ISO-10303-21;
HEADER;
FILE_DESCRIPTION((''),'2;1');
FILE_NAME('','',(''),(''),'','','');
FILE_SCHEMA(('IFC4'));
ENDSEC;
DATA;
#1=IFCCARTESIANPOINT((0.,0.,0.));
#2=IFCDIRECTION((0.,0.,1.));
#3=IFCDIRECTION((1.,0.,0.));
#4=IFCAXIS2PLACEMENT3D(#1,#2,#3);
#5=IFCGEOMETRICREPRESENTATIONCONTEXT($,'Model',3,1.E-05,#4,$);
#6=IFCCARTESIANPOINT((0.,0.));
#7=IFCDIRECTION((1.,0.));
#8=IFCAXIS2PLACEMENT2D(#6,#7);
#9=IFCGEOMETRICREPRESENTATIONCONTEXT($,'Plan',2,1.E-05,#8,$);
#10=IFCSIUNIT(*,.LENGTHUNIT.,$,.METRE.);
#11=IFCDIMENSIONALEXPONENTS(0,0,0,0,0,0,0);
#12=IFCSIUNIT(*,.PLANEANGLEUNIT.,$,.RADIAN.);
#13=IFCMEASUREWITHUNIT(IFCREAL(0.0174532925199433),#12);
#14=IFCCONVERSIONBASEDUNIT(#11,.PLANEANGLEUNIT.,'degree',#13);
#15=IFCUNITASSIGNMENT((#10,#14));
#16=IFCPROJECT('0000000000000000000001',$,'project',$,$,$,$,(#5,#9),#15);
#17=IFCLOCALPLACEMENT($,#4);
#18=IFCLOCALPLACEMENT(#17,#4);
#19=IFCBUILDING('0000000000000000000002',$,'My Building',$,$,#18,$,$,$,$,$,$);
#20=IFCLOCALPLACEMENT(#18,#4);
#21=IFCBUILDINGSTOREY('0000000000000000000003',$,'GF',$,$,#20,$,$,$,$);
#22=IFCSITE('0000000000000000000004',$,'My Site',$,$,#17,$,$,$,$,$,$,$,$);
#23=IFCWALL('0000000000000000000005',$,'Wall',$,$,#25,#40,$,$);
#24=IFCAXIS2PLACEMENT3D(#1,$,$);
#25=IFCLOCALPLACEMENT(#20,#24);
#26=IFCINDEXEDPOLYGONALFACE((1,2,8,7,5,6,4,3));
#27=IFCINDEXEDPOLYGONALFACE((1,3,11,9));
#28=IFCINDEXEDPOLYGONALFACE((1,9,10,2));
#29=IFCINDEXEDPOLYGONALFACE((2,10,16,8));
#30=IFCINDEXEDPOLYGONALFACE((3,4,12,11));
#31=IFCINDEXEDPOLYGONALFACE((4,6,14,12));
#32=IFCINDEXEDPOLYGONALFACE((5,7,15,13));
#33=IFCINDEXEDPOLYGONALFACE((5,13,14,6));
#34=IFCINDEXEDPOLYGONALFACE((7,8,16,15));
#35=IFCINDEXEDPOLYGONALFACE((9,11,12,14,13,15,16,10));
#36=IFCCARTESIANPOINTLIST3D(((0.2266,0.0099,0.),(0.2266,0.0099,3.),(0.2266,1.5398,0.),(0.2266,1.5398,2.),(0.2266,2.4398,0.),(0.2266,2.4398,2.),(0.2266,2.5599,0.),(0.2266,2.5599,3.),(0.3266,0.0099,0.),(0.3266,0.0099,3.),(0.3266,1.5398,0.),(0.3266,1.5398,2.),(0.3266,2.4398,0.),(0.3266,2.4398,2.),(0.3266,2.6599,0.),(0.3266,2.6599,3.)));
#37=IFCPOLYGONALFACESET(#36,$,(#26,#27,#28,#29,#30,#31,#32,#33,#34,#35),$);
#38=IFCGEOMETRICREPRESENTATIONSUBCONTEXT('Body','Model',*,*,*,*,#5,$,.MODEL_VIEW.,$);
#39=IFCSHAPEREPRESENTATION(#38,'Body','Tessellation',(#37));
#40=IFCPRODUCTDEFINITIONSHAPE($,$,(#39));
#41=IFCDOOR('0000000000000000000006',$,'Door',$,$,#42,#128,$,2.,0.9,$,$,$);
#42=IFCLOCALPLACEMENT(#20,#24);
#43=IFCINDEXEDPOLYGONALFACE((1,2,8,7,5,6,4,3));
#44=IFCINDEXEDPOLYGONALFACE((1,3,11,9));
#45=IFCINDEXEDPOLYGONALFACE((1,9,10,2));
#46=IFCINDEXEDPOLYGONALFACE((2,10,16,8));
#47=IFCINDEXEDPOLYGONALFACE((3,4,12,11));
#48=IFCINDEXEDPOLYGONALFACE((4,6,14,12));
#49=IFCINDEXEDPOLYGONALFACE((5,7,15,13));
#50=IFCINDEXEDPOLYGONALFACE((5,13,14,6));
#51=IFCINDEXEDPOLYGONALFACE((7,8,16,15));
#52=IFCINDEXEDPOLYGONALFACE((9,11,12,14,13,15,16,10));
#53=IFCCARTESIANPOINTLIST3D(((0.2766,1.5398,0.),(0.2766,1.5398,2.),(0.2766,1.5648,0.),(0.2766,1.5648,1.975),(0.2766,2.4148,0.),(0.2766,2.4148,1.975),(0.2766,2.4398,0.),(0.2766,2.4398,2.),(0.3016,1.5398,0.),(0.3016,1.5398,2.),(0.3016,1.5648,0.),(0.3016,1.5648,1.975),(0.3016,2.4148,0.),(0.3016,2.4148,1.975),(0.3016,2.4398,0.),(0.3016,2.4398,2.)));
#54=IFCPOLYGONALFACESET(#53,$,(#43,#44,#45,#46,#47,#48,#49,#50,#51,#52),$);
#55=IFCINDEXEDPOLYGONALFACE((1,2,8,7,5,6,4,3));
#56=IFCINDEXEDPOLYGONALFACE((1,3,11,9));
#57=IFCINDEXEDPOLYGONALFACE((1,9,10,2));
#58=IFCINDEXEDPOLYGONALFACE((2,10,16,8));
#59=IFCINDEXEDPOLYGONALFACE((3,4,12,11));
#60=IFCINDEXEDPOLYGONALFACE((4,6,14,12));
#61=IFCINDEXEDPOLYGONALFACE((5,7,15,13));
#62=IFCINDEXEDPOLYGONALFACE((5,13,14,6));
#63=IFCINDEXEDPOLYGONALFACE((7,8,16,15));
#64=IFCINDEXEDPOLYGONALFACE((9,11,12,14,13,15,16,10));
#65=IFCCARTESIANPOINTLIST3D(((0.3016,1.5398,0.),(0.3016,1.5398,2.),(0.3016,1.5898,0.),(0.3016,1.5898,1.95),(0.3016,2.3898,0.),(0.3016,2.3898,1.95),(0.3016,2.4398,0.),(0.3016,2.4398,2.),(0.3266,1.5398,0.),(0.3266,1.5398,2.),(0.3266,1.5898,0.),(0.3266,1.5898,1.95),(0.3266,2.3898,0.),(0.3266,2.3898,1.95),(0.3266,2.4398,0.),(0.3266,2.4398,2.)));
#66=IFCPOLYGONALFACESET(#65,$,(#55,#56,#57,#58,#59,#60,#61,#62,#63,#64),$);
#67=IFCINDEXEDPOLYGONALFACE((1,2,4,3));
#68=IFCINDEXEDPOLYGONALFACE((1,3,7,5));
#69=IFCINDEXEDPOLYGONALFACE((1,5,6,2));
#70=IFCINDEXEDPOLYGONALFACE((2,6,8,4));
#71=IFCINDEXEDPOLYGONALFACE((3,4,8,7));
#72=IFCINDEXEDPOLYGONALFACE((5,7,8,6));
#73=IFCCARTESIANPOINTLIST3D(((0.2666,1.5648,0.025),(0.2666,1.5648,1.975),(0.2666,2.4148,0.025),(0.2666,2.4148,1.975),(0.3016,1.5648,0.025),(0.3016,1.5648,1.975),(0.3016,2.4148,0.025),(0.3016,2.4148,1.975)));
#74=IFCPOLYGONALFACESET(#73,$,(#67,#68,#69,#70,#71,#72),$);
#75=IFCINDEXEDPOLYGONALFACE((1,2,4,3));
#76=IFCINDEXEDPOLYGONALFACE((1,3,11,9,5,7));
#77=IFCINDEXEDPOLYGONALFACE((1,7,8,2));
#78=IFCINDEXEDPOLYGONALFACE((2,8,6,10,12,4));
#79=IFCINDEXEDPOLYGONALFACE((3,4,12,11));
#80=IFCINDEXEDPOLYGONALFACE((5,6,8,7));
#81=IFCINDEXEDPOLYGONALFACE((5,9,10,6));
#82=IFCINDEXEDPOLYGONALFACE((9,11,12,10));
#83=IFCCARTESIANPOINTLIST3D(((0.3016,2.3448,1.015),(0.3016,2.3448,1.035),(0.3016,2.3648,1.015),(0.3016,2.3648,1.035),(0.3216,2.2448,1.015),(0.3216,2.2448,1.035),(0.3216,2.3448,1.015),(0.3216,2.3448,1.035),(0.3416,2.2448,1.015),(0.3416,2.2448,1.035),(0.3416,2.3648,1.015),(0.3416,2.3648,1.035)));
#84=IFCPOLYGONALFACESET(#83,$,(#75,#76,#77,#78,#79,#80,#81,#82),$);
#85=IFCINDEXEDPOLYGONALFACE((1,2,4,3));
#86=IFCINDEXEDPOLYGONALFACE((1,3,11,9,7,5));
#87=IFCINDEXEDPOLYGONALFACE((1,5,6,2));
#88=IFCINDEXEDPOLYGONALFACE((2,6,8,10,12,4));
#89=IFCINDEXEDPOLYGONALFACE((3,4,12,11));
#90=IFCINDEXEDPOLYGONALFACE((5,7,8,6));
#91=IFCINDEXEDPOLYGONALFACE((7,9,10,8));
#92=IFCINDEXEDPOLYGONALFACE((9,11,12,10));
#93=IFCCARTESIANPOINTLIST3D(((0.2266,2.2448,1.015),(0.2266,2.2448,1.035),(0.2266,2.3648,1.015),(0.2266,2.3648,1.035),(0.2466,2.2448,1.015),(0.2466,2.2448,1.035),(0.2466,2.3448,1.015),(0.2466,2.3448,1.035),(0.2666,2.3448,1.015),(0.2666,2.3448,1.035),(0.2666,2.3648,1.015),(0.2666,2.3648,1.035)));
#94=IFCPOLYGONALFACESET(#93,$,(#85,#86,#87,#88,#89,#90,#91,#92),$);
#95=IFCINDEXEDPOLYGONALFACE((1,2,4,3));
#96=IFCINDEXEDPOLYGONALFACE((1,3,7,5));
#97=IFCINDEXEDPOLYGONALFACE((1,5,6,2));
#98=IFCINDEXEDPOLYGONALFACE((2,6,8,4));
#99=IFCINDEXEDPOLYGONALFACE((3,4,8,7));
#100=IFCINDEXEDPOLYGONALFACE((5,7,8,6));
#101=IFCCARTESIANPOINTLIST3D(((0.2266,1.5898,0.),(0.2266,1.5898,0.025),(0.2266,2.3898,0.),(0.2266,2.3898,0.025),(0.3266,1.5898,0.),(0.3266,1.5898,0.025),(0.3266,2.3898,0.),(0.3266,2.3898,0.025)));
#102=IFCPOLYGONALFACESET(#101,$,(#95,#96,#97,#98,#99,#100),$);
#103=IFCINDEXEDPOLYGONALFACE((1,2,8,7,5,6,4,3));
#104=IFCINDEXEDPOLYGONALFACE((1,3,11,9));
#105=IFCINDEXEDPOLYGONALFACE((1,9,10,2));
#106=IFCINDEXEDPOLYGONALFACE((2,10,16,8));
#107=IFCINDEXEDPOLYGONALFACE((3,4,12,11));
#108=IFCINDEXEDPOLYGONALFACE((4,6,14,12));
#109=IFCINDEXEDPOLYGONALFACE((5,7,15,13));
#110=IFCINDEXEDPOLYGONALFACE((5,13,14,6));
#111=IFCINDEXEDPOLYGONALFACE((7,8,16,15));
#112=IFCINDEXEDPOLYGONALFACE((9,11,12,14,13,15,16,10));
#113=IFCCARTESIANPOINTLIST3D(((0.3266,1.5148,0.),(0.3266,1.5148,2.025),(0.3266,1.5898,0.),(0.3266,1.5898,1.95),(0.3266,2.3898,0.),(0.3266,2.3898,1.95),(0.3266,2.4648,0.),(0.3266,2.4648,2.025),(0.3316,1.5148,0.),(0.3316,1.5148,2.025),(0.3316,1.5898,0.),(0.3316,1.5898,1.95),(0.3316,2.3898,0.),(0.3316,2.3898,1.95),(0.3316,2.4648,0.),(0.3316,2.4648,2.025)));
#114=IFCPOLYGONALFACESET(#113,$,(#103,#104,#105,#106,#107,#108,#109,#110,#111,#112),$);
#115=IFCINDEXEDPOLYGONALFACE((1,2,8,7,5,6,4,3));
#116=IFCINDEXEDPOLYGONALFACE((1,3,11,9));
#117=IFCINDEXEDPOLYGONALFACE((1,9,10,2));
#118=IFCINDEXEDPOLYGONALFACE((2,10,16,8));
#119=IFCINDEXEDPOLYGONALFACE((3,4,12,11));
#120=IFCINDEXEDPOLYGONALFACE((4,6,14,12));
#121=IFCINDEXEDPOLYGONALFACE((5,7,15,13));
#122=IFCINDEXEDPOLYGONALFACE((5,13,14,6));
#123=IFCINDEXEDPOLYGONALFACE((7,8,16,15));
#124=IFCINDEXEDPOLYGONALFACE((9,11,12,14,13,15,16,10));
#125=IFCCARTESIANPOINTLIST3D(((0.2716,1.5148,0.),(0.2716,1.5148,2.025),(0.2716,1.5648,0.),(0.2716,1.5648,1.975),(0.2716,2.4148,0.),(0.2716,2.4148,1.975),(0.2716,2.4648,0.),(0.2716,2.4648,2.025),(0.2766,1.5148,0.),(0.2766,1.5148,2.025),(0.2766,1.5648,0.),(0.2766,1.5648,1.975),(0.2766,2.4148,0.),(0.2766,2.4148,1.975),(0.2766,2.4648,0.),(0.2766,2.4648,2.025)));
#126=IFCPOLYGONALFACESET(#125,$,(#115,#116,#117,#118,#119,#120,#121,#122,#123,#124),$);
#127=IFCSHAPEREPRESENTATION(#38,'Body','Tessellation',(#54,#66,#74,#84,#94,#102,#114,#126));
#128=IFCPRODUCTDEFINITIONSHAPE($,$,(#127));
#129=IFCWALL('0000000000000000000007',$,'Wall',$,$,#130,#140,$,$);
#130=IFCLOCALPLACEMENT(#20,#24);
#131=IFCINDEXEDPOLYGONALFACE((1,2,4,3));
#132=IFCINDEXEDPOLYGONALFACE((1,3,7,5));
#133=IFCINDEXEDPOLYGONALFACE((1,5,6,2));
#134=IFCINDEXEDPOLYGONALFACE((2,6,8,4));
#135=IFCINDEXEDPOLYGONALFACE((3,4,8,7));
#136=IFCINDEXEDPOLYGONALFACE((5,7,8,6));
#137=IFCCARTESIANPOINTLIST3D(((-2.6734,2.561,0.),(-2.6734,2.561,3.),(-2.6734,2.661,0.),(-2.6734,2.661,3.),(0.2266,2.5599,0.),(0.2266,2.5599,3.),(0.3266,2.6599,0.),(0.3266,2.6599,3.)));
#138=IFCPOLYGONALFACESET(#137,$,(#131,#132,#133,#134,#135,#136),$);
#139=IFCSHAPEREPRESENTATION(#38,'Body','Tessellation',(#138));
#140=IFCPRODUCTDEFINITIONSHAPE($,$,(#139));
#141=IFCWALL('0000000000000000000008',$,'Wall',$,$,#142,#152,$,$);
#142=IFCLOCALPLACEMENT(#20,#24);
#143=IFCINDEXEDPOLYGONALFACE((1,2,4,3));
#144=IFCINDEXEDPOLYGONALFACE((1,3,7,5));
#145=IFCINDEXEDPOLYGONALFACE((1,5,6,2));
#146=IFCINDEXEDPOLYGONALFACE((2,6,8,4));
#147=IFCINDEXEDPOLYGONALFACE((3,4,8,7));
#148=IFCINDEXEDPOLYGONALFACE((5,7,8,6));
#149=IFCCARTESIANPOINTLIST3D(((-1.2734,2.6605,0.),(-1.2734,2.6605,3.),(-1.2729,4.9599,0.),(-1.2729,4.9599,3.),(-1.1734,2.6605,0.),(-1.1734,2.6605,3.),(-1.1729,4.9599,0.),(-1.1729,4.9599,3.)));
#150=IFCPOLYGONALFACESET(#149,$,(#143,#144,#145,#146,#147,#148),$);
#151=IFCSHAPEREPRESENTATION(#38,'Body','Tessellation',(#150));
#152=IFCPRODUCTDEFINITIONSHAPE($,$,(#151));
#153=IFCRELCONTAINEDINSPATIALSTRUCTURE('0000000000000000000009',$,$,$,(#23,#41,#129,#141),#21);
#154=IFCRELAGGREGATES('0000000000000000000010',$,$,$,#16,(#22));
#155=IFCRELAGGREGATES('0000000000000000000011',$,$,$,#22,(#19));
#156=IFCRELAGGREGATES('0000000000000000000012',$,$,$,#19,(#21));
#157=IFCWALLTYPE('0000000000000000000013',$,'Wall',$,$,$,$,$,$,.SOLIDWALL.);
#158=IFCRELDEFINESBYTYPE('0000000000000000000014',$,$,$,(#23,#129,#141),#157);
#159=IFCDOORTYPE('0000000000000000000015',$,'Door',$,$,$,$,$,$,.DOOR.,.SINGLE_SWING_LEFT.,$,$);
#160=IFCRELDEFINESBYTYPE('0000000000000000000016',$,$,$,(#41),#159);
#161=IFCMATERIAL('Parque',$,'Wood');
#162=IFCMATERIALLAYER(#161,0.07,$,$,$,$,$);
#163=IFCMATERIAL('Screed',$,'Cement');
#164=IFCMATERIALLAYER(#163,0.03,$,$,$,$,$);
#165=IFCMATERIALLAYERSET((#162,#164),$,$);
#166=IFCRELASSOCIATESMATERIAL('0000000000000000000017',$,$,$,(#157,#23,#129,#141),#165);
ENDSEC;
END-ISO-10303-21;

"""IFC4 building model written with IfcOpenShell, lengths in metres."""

from ifc_helpers import new_model, entity, si_unit, converted_unit, frame, origin_with_axes, origin_2d_with_axis, place, context, subcontext, project, spatial, line, indexed_curve, outline, extrude, shape, source, transform, mapped, material, layer, layer_set, layer_usage, type_object, type_shapes, element, fill, save


model = new_model("IFC4")

# Units and contexts
model_context = context("Model", 3, precision=1e-05, world=origin_with_axes())
plan_context = context("Plan", 2, precision=1e-05, world=origin_2d_with_axis())
body_context_1 = subcontext(model_context, "Body", "Model", "MODEL_VIEW")
body_context_2 = subcontext(plan_context, "Body", "Plan", "PLAN_VIEW")
ifc_project = project(units=[si_unit("LENGTHUNIT", "METRE"), converted_unit("PLANEANGLEUNIT", "degree", entity("IfcReal", 0.0174532925199433), si_unit("PLANEANGLEUNIT", "RADIAN"), dimensions=[0, 0, 0, 0, 0, 0, 0])], contexts=[model_context, plan_context])

# Site, building, storey
site_placement = place(None, origin_with_axes())
site = spatial("IfcSite", under=ifc_project, at=site_placement, Name="My Site")
building_placement = place(site_placement, origin_with_axes())
building = spatial("IfcBuilding", under=site, at=building_placement, Name="My Building")
storey_placement = place(building_placement, origin_with_axes())
storey = spatial("IfcBuildingStorey", under=building, at=storey_placement, Name="GF")

# Shared definitions
ifc_material_1 = material(Name="Parque", Category="Wood")
ifc_layer_1 = layer(ifc_material_1, 0.07)
ifc_material_2 = material(Name="Screed", Category="Cement")
ifc_layer_2 = layer(ifc_material_2, 0.03)
ifc_layer_set_1 = layer_set([ifc_layer_1, ifc_layer_2])
wall_type = type_object("IfcWallType", Name="Wall", PredefinedType="SOLIDWALL", material=ifc_layer_set_1)
shared_shape_1 = source(origin_with_axes(), body_context_1, "Body", "SweptSolid", [
    extrude(outline(indexed_curve([(0.0, 0.0), (0.9, 0.0), (0.9, 2.0), (0.0, 2.0)], segments=[line(1, 2, 3, 4, 1)])), frame((0.0, -0.6, 0.0), z_axis=(0.0, -1.0, 0.0), x_axis=(1.0, 0.0, 0.0)), (0.0, 0.0, -1.0), 1.2),
])
door_type = type_object("IfcDoorType", Name="Door", OperationType="SINGLE_SWING_LEFT", PredefinedType="DOOR")
shared_shape_2 = source(origin_with_axes(), body_context_1, "Body", "SweptSolid", [
    extrude(outline(indexed_curve([(0.0, 0.0), (0.0, 2.0), (0.9, 2.0), (0.9, 0.0), (0.875, 0.0), (0.875, 1.975), (0.025, 1.975), (0.025, 0.0)], segments=[line(1, 2, 3, 4, 5, 6, 7, 8, 1)])), frame((0.0, 0.025, 0.0), z_axis=(0.0, -1.0, 0.0), x_axis=(1.0, 0.0, 0.0)), (0.0, 0.0, -1.0), 0.025),
    extrude(outline(indexed_curve([(0.0, 0.0), (0.0, 2.0), (0.9, 2.0), (0.9, 0.0), (0.85, 0.0), (0.85, 1.95), (0.05, 1.95), (0.05, 0.0)], segments=[line(1, 2, 3, 4, 5, 6, 7, 8, 1)])), frame((0.0, 0.0, 0.0), z_axis=(0.0, -1.0, 0.0), x_axis=(1.0, 0.0, 0.0)), (0.0, 0.0, -1.0), 0.025),
    extrude(outline(indexed_curve([(0.0, 0.0), (0.85, 0.0), (0.85, 0.035), (0.0, 0.035)], segments=[line(1, 2, 3, 4, 1)])), frame((0.025, 0.025, 0.025), z_axis=(0.0, 0.0, 1.0), x_axis=(1.0, 0.0, 0.0)), (0.0, 0.0, 1.0), 1.95),
    extrude(outline(indexed_curve([(0.0, 0.0), (0.0, -0.04), (-0.12, -0.04), (-0.12, -0.02), (-0.02, -0.02), (-0.02, 0.0)], segments=[line(1, 2, 3, 4, 5, 6, 1)])), frame((0.825, 0.025, 1.015), z_axis=(0.0, 0.0, 1.0), x_axis=(1.0, 0.0, 0.0)), (0.0, 0.0, 1.0), 0.02),
    extrude(outline(indexed_curve([(0.0, 0.0), (0.0, 0.04), (-0.12, 0.04), (-0.12, 0.02), (-0.02, 0.02), (-0.02, 0.0)], segments=[line(1, 2, 3, 4, 5, 6, 1)])), frame((0.825, 0.06, 1.015), z_axis=(0.0, 0.0, 1.0), x_axis=(1.0, 0.0, 0.0)), (0.0, 0.0, 1.0), 0.02),
    extrude(outline(indexed_curve([(0.0, 0.0), (0.8, 0.0), (0.8, 0.1), (0.0, 0.1)], segments=[line(1, 2, 3, 4, 1)])), frame((0.05, 0.0, 0.0), z_axis=(0.0, 0.0, 1.0), x_axis=(1.0, 0.0, 0.0)), (0.0, 0.0, 1.0), 0.025),
    extrude(outline(indexed_curve([(0.0, 0.0), (0.0, 2.025), (0.95, 2.025), (0.95, 0.0), (0.875, 0.0), (0.875, 1.95), (0.075, 1.95), (0.075, 0.0)], segments=[line(1, 2, 3, 4, 5, 6, 7, 8, 1)])), frame((-0.025, -0.005, 0.0), z_axis=(0.0, -1.0, 0.0), x_axis=(1.0, 0.0, 0.0)), (0.0, 0.0, -1.0), 0.005),
    extrude(outline(indexed_curve([(0.0, 0.0), (0.0, 2.025), (0.95, 2.025), (0.95, 0.0), (0.9, 0.0), (0.9, 1.975), (0.05, 1.975), (0.05, 0.0)], segments=[line(1, 2, 3, 4, 5, 6, 7, 8, 1)])), frame((-0.025, 0.05, 0.0), z_axis=(0.0, -1.0, 0.0), x_axis=(1.0, 0.0, 0.0)), (0.0, 0.0, -1.0), 0.005),
])
shared_shape_3 = source(origin_with_axes(), body_context_2, "Body", "Curve2D", [
    entity("IfcIndexedPolyCurve", entity("IfcCartesianPointList2D", [[0.0, 0.0], [0.0, 0.05], [0.025, 0.05], [0.025, 0.025], [0.05, 0.025], [0.05, 0.0]]), [entity("IfcLineIndex", [1, 2, 3, 4, 5, 6, 1])]),
    entity("IfcIndexedPolyCurve", entity("IfcCartesianPointList2D", [[0.9, 0.0], [0.9, 0.05], [0.875, 0.05], [0.875, 0.025], [0.85, 0.025], [0.85, 0.0]]), [entity("IfcLineIndex", [1, 2, 3, 4, 5, 6, 1])]),
    entity("IfcTrimmedCurve", entity("IfcEllipse", entity("IfcAxis2Placement2D", entity("IfcCartesianPoint", [0.06, 0.05]), entity("IfcDirection", [1.0, 0.0])), 0.815, 0.85), [entity("IfcCartesianPoint", [0.875, 0.05])], [entity("IfcCartesianPoint", [0.06, 0.9])], True, "CARTESIAN"),
    entity("IfcIndexedPolyCurve", entity("IfcCartesianPointList2D", [[0.025, 0.05], [0.06, 0.05], [0.06, 0.9], [0.025, 0.9]]), [entity("IfcLineIndex", [1, 2, 3, 4, 1])]),
])
type_shapes(door_type, [shared_shape_2, shared_shape_3])

# Wall, opening, door
ifc_layer_usage_1 = layer_usage(ifc_layer_set_1, "AXIS2", "POSITIVE", 0.0)
wall_1_placement = place(storey_placement, frame((0.3266, 0.0099, 0.0), z_axis=(0.0, 0.0, 1.0), x_axis=(0.0, 1.0, 0.0)))
wall_1 = element("IfcWall", 1, at=wall_1_placement, inside=storey, type_object=wall_type, material=ifc_layer_usage_1, Name="Wall", context=body_context_1, shape_type="SweptSolid", body=[
    extrude(outline(indexed_curve([(0.0, 0.0), (0.0, 0.1), (2.55, 0.1), (2.65, 0.0)], segments=[line(1, 2, 3, 4, 1)])), origin_with_axes(), (0.0, 0.0, 1.0), 3.0),
])
opening_1_placement = place(wall_1_placement, frame((1.5299, 0.0, 0.0), z_axis=(0.0, 0.0, 1.0), x_axis=(1.0, 0.0, 0.0)))
opening_1 = element("IfcOpeningElement", 2, at=opening_1_placement, cuts=wall_1, PredefinedType="OPENING", context=body_context_1, shape_type="MappedRepresentation", body=[
    mapped(shared_shape_1, transform((0.0, 0.0, 0.0), x_axis=(1.0, 0.0, 0.0), y_axis=(0.0, 1.0, 0.0), z_axis=(0.0, 0.0, 1.0), scale=1.0)),
])
door_1_placement = place(opening_1_placement, frame((0.0, 0.0, 0.0), z_axis=(0.0, 0.0, 1.0), x_axis=(1.0, 0.0, 0.0)))
door_1 = element("IfcDoor", 3, at=door_1_placement, inside=storey, type_object=door_type, Name="Door", OverallHeight=2.0, OverallWidth=0.9, shapes=[
    shape(body_context_1, "Body", "MappedRepresentation", [mapped(shared_shape_2, transform((0.0, 0.0, 0.0), x_axis=(1.0, 0.0, 0.0), y_axis=(0.0, 1.0, 0.0), z_axis=(0.0, 0.0, 1.0), scale=1.0))]),
    shape(body_context_2, "Body", "MappedRepresentation", [mapped(shared_shape_3, transform((0.0, 0.0, 0.0), x_axis=(1.0, 0.0, 0.0), y_axis=(0.0, 1.0, 0.0), z_axis=(0.0, 0.0, 1.0), scale=1.0))]),
])
fill(opening_1, door_1)

# Walls
ifc_layer_usage_2 = layer_usage(ifc_layer_set_1, "AXIS2", "POSITIVE", 0.0)
wall_2_placement = place(storey_placement, frame((0.3266, 2.6599, 0.0), z_axis=(0.0, 0.0, 1.0), x_axis=(-1.0, 0.000381, 0.0)))
element("IfcWall", 4, at=wall_2_placement, inside=storey, type_object=wall_type, material=ifc_layer_usage_2, Name="Wall", context=body_context_1, shape_type="SweptSolid", body=[
    extrude(outline(indexed_curve([(0.0, 0.0), (0.1, 0.1), (3.0, 0.1), (3.0, 0.0)], segments=[line(1, 2, 3, 4, 1)])), origin_with_axes(), (0.0, 0.0, 1.0), 3.0),
])
ifc_layer_usage_3 = layer_usage(ifc_layer_set_1, "AXIS2", "POSITIVE", 0.0)
wall_3_placement = place(storey_placement, frame((-1.1734, 2.6605, 0.0), z_axis=(0.0, 0.0, 1.0), x_axis=(0.000197, 1.0, 0.0)))
element("IfcWall", 5, at=wall_3_placement, inside=storey, type_object=wall_type, material=ifc_layer_usage_3, Name="Wall", context=body_context_1, shape_type="SweptSolid", body=[
    extrude(outline(indexed_curve([(0.0, 0.0), (0.0, 0.1), (2.2994, 0.1), (2.2994, 0.0)], segments=[line(1, 2, 3, 4, 1)])), origin_with_axes(), (0.0, 0.0, 1.0), 3.0),
])

save(model, "model.ifc")
